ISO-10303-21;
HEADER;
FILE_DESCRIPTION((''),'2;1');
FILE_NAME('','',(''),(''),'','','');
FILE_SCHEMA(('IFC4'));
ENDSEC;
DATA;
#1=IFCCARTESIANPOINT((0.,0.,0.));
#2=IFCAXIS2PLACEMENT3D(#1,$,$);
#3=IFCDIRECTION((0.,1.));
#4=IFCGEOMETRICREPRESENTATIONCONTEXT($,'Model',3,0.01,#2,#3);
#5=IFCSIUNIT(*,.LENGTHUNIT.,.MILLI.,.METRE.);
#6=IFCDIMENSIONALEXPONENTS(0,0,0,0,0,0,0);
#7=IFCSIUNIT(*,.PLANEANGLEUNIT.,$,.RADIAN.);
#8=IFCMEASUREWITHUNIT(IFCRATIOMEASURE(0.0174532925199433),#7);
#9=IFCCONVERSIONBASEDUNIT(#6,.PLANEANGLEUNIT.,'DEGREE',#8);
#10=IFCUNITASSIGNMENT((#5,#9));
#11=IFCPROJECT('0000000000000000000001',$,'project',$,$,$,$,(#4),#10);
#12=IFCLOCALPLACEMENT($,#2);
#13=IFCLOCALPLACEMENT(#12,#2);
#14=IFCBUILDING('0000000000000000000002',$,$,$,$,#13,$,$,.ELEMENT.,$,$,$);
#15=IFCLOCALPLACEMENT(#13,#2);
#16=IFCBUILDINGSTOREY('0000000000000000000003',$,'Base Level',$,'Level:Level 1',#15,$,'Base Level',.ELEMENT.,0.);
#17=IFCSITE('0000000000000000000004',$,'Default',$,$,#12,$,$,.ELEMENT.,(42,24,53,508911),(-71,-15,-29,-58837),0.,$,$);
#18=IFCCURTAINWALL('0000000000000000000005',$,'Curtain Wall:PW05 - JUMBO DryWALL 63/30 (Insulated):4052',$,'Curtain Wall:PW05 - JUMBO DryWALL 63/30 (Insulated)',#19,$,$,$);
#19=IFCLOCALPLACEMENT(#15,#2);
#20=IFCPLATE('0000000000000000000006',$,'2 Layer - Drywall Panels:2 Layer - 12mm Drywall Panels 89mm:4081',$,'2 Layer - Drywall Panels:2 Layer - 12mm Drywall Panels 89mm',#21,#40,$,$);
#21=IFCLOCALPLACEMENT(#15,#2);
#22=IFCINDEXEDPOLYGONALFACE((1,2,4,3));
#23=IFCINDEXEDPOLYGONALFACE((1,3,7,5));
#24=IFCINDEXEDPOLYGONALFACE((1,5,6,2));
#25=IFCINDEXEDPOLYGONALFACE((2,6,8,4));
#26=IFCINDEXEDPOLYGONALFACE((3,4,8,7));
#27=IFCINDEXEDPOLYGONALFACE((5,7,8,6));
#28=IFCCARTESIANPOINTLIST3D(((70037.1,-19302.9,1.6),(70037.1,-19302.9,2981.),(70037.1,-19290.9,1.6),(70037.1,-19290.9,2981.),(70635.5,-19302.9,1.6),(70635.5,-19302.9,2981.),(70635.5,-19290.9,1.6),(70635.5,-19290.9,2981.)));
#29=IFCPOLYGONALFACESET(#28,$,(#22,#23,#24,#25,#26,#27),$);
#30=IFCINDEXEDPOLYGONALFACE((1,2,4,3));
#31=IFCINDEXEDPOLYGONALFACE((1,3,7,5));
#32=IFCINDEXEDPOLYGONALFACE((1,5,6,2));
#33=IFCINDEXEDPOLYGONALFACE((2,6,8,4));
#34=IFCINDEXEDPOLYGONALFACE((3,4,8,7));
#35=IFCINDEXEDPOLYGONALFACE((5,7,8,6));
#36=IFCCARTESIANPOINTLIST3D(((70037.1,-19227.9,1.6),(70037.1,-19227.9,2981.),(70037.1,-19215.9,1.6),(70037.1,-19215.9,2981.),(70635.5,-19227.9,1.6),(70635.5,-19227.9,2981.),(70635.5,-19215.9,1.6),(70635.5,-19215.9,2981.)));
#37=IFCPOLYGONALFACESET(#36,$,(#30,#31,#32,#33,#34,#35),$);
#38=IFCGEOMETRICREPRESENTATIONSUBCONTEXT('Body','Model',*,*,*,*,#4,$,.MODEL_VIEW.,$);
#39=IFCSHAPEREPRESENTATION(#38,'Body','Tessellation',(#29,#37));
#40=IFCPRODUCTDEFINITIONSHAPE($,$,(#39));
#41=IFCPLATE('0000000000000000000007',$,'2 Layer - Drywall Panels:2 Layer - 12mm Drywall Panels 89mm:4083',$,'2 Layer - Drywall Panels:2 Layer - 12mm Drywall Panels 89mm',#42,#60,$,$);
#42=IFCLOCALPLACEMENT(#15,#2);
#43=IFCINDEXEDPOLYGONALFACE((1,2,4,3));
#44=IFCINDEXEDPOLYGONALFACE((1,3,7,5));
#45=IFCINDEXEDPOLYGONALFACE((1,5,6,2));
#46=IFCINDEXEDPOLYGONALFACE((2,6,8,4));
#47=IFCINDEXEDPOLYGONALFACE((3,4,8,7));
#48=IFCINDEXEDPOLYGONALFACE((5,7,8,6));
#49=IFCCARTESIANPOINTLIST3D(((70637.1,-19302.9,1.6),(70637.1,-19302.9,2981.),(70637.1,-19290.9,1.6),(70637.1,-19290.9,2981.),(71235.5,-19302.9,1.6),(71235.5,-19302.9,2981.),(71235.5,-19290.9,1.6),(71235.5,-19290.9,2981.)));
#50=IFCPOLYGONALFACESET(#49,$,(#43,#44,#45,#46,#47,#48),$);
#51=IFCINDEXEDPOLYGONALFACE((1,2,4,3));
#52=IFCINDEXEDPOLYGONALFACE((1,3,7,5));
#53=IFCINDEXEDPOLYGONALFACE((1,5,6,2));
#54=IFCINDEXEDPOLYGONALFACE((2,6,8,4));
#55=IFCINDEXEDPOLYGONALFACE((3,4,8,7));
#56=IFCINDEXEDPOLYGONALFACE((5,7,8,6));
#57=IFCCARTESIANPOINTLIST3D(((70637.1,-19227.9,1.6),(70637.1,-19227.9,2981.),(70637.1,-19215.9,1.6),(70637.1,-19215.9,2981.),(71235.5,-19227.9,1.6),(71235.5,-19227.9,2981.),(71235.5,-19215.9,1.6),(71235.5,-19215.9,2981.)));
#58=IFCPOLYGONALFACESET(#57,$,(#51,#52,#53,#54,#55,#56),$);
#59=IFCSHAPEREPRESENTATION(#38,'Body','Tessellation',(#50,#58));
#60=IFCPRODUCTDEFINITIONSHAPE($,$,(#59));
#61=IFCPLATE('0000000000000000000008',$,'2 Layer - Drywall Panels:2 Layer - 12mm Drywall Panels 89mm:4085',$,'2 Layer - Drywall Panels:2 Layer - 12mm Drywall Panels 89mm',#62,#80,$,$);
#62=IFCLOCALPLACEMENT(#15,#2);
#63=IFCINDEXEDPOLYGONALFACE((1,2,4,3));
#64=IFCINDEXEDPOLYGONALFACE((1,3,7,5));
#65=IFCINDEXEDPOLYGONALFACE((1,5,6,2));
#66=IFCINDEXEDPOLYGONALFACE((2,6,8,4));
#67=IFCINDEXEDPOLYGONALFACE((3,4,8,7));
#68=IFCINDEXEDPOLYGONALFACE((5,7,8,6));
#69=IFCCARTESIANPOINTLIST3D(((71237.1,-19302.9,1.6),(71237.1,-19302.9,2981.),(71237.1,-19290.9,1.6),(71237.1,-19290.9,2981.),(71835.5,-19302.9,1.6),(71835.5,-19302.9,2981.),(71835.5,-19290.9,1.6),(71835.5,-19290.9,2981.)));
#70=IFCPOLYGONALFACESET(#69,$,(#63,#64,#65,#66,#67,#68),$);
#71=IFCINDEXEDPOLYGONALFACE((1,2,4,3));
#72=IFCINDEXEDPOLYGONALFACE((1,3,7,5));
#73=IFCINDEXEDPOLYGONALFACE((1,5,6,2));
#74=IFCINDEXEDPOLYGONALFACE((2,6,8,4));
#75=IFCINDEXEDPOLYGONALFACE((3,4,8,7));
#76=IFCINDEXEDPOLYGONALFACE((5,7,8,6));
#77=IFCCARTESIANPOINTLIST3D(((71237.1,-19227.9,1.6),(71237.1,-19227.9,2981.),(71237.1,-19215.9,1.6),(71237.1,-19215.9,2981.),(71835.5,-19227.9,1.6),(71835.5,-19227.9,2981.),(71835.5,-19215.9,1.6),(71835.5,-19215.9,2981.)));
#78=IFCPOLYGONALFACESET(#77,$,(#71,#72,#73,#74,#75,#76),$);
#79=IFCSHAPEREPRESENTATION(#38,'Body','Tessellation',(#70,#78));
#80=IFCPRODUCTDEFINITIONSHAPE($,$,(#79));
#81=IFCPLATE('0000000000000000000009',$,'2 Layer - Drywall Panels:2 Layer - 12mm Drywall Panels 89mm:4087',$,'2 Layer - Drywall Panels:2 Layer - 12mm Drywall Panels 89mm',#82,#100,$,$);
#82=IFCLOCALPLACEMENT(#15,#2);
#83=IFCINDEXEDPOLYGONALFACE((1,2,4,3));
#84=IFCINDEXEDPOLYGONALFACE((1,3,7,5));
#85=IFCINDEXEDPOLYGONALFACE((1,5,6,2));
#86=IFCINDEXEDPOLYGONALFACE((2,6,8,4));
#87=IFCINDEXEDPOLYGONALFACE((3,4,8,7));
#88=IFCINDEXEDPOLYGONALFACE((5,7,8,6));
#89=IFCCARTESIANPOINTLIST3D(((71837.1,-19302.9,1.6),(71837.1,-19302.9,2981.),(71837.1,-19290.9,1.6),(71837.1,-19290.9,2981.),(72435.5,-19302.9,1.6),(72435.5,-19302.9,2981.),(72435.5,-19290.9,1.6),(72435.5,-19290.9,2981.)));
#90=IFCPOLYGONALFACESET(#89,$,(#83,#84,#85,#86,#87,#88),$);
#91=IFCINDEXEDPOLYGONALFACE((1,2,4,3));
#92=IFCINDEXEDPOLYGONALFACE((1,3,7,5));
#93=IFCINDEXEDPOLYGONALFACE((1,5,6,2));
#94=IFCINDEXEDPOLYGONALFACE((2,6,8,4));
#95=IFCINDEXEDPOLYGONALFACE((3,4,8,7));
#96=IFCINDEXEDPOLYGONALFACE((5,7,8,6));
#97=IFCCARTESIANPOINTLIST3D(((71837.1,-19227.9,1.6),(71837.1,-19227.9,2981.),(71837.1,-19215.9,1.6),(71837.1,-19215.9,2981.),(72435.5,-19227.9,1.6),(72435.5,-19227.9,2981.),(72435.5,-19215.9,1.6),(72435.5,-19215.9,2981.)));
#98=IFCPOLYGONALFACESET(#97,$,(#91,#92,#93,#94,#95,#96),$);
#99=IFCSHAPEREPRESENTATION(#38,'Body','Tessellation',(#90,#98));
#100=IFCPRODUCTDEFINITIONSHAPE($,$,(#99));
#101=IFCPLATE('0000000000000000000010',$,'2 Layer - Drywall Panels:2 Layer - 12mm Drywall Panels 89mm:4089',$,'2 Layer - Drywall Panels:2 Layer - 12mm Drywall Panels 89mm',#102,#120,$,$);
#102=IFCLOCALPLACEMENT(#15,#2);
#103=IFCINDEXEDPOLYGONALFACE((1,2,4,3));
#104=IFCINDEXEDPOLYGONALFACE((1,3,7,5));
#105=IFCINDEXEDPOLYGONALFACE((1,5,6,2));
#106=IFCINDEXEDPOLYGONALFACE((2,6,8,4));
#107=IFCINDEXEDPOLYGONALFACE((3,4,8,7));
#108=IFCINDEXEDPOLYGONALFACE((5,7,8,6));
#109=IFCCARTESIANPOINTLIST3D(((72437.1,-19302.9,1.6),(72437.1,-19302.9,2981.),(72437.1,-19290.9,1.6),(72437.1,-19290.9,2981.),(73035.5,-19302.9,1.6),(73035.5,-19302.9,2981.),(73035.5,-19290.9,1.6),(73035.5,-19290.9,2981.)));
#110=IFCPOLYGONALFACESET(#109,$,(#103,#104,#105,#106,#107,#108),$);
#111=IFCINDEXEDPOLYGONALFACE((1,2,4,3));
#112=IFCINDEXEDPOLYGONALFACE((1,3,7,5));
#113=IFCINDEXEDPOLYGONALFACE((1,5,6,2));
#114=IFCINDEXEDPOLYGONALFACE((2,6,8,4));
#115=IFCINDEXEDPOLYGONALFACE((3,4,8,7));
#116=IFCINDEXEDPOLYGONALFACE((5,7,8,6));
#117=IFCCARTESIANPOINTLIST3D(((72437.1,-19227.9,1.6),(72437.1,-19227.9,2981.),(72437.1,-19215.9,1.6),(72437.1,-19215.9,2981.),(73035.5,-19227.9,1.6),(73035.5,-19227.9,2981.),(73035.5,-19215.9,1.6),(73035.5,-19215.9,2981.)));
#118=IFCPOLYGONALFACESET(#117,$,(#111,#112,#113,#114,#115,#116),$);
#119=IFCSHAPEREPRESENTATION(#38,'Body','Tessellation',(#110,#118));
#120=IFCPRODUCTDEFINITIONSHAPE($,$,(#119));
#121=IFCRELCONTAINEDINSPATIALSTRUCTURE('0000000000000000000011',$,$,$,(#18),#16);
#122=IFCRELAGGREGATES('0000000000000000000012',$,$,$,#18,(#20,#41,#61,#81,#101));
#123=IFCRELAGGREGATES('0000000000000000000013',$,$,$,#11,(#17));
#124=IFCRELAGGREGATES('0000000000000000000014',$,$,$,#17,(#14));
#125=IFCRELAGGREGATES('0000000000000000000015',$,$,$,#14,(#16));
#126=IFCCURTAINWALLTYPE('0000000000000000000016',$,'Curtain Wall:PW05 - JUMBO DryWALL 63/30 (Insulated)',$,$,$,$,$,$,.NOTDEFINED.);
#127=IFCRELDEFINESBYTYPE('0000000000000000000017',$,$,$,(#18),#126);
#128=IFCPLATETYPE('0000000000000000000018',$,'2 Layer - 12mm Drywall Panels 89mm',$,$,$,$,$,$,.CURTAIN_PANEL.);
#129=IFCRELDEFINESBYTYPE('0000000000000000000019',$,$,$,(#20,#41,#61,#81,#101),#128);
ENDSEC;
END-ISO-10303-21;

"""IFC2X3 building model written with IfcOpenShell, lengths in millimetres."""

from ifc_helpers import new_model, entity, si_unit, converted_unit, direction, frame, frame_2d, origin, place, context, subcontext, project, spatial, rectangle, extrude, source, transform, mapped, type_object, type_shapes, element, aggregate, save


model = new_model("IFC2X3")

# Units and contexts
model_context = context("Model", 3, precision=0.01, world=origin(), true_north=direction((0.0, 1.0)))
body_context = subcontext(model_context, "Body", "Model", "MODEL_VIEW")
ifc_project = project(units=[si_unit("LENGTHUNIT", "METRE", prefix="MILLI"), converted_unit("PLANEANGLEUNIT", "DEGREE", entity("IfcRatioMeasure", 0.0174532925199433), si_unit("PLANEANGLEUNIT", "RADIAN"), dimensions=[0, 0, 0, 0, 0, 0, 0])], contexts=[model_context])

# Site, building, storey
site_placement = place(None, origin())
site = spatial("IfcSite", under=ifc_project, at=site_placement, Name="Default", CompositionType="ELEMENT", RefLatitude=(42, 24, 53, 508911), RefLongitude=(-71, -15, -29, -58837), RefElevation=0.0)
building_placement = place(site_placement, origin())
building = spatial("IfcBuilding", under=site, at=building_placement, CompositionType="ELEMENT")
storey_placement = place(building_placement, origin())
storey = spatial("IfcBuildingStorey", under=building, at=storey_placement, Name="Base Level", ObjectType="Level:Level 1", LongName="Base Level", CompositionType="ELEMENT", Elevation=0.0)

# Curtain wall, plates
curtain_wall_type = type_object("IfcCurtainWallType", Name="Curtain Wall:PW05 - JUMBO DryWALL 63/30 (Insulated)", PredefinedType="NOTDEFINED")
curtain_wall_placement = place(building_placement, origin())
curtain_wall = element("IfcCurtainWall", 1, at=curtain_wall_placement, inside=storey, type_object=curtain_wall_type, Name="Curtain Wall:PW05 - JUMBO DryWALL 63/30 (Insulated):4052", ObjectType="Curtain Wall:PW05 - JUMBO DryWALL 63/30 (Insulated)")
plate_type = type_object("IfcPlateType", Name="2 Layer - 12mm Drywall Panels 89mm", PredefinedType="CURTAIN_PANEL")
shared_shape_1 = source(origin(), body_context, "Body", "SweptSolid", [
    extrude(rectangle(XDim=598.4, YDim=12.0, at=frame_2d((0.0, 0.0), x_axis=(1.0, 0.0))), frame((0.0, -37.5, 0.0), z_axis=(0.0, 0.0, 1.0), x_axis=(-1.0, 0.0, 0.0)), (0.0, 0.0, 1.0), 2979.4),
    extrude(rectangle(XDim=12.0, YDim=598.4, at=frame_2d((0.0, 0.0), x_axis=(1.0, 0.0))), frame((0.0, 37.5, 0.0), z_axis=(0.0, 0.0, 1.0), x_axis=(0.0, 1.0, 0.0)), (0.0, 0.0, 1.0), 2979.4),
])
type_shapes(plate_type, [shared_shape_1])
plate_1_placement = place(curtain_wall_placement, frame((70336.3, -19259.4, 1.6)))
plate_1 = element("IfcPlate", 2, at=plate_1_placement, type_object=plate_type, Name="2 Layer - Drywall Panels:2 Layer - 12mm Drywall Panels 89mm:4081", ObjectType="2 Layer - Drywall Panels:2 Layer - 12mm Drywall Panels 89mm", context=body_context, shape_type="MappedRepresentation", body=[
    mapped(shared_shape_1, transform((0.0, 0.0, 0.0), scale=1.0)),
])
plate_2_placement = place(curtain_wall_placement, frame((70936.3, -19259.4, 1.6)))
plate_2 = element("IfcPlate", 3, at=plate_2_placement, type_object=plate_type, Name="2 Layer - Drywall Panels:2 Layer - 12mm Drywall Panels 89mm:4083", ObjectType="2 Layer - Drywall Panels:2 Layer - 12mm Drywall Panels 89mm", context=body_context, shape_type="MappedRepresentation", body=[
    mapped(shared_shape_1, transform((0.0, 0.0, 0.0), scale=1.0)),
])
plate_3_placement = place(curtain_wall_placement, frame((71536.3, -19259.4, 1.6)))
plate_3 = element("IfcPlate", 4, at=plate_3_placement, type_object=plate_type, Name="2 Layer - Drywall Panels:2 Layer - 12mm Drywall Panels 89mm:4085", ObjectType="2 Layer - Drywall Panels:2 Layer - 12mm Drywall Panels 89mm", context=body_context, shape_type="MappedRepresentation", body=[
    mapped(shared_shape_1, transform((0.0, 0.0, 0.0), scale=1.0)),
])
plate_4_placement = place(curtain_wall_placement, frame((72136.3, -19259.4, 1.6)))
plate_4 = element("IfcPlate", 5, at=plate_4_placement, type_object=plate_type, Name="2 Layer - Drywall Panels:2 Layer - 12mm Drywall Panels 89mm:4087", ObjectType="2 Layer - Drywall Panels:2 Layer - 12mm Drywall Panels 89mm", context=body_context, shape_type="MappedRepresentation", body=[
    mapped(shared_shape_1, transform((0.0, 0.0, 0.0), scale=1.0)),
])
plate_5_placement = place(curtain_wall_placement, frame((72736.3, -19259.4, 1.6)))
plate_5 = element("IfcPlate", 6, at=plate_5_placement, type_object=plate_type, Name="2 Layer - Drywall Panels:2 Layer - 12mm Drywall Panels 89mm:4089", ObjectType="2 Layer - Drywall Panels:2 Layer - 12mm Drywall Panels 89mm", context=body_context, shape_type="MappedRepresentation", body=[
    mapped(shared_shape_1, transform((0.0, 0.0, 0.0), scale=1.0)),
])
aggregate(curtain_wall, [plate_1, plate_2, plate_3, plate_4, plate_5])

save(model, "model.ifc")
